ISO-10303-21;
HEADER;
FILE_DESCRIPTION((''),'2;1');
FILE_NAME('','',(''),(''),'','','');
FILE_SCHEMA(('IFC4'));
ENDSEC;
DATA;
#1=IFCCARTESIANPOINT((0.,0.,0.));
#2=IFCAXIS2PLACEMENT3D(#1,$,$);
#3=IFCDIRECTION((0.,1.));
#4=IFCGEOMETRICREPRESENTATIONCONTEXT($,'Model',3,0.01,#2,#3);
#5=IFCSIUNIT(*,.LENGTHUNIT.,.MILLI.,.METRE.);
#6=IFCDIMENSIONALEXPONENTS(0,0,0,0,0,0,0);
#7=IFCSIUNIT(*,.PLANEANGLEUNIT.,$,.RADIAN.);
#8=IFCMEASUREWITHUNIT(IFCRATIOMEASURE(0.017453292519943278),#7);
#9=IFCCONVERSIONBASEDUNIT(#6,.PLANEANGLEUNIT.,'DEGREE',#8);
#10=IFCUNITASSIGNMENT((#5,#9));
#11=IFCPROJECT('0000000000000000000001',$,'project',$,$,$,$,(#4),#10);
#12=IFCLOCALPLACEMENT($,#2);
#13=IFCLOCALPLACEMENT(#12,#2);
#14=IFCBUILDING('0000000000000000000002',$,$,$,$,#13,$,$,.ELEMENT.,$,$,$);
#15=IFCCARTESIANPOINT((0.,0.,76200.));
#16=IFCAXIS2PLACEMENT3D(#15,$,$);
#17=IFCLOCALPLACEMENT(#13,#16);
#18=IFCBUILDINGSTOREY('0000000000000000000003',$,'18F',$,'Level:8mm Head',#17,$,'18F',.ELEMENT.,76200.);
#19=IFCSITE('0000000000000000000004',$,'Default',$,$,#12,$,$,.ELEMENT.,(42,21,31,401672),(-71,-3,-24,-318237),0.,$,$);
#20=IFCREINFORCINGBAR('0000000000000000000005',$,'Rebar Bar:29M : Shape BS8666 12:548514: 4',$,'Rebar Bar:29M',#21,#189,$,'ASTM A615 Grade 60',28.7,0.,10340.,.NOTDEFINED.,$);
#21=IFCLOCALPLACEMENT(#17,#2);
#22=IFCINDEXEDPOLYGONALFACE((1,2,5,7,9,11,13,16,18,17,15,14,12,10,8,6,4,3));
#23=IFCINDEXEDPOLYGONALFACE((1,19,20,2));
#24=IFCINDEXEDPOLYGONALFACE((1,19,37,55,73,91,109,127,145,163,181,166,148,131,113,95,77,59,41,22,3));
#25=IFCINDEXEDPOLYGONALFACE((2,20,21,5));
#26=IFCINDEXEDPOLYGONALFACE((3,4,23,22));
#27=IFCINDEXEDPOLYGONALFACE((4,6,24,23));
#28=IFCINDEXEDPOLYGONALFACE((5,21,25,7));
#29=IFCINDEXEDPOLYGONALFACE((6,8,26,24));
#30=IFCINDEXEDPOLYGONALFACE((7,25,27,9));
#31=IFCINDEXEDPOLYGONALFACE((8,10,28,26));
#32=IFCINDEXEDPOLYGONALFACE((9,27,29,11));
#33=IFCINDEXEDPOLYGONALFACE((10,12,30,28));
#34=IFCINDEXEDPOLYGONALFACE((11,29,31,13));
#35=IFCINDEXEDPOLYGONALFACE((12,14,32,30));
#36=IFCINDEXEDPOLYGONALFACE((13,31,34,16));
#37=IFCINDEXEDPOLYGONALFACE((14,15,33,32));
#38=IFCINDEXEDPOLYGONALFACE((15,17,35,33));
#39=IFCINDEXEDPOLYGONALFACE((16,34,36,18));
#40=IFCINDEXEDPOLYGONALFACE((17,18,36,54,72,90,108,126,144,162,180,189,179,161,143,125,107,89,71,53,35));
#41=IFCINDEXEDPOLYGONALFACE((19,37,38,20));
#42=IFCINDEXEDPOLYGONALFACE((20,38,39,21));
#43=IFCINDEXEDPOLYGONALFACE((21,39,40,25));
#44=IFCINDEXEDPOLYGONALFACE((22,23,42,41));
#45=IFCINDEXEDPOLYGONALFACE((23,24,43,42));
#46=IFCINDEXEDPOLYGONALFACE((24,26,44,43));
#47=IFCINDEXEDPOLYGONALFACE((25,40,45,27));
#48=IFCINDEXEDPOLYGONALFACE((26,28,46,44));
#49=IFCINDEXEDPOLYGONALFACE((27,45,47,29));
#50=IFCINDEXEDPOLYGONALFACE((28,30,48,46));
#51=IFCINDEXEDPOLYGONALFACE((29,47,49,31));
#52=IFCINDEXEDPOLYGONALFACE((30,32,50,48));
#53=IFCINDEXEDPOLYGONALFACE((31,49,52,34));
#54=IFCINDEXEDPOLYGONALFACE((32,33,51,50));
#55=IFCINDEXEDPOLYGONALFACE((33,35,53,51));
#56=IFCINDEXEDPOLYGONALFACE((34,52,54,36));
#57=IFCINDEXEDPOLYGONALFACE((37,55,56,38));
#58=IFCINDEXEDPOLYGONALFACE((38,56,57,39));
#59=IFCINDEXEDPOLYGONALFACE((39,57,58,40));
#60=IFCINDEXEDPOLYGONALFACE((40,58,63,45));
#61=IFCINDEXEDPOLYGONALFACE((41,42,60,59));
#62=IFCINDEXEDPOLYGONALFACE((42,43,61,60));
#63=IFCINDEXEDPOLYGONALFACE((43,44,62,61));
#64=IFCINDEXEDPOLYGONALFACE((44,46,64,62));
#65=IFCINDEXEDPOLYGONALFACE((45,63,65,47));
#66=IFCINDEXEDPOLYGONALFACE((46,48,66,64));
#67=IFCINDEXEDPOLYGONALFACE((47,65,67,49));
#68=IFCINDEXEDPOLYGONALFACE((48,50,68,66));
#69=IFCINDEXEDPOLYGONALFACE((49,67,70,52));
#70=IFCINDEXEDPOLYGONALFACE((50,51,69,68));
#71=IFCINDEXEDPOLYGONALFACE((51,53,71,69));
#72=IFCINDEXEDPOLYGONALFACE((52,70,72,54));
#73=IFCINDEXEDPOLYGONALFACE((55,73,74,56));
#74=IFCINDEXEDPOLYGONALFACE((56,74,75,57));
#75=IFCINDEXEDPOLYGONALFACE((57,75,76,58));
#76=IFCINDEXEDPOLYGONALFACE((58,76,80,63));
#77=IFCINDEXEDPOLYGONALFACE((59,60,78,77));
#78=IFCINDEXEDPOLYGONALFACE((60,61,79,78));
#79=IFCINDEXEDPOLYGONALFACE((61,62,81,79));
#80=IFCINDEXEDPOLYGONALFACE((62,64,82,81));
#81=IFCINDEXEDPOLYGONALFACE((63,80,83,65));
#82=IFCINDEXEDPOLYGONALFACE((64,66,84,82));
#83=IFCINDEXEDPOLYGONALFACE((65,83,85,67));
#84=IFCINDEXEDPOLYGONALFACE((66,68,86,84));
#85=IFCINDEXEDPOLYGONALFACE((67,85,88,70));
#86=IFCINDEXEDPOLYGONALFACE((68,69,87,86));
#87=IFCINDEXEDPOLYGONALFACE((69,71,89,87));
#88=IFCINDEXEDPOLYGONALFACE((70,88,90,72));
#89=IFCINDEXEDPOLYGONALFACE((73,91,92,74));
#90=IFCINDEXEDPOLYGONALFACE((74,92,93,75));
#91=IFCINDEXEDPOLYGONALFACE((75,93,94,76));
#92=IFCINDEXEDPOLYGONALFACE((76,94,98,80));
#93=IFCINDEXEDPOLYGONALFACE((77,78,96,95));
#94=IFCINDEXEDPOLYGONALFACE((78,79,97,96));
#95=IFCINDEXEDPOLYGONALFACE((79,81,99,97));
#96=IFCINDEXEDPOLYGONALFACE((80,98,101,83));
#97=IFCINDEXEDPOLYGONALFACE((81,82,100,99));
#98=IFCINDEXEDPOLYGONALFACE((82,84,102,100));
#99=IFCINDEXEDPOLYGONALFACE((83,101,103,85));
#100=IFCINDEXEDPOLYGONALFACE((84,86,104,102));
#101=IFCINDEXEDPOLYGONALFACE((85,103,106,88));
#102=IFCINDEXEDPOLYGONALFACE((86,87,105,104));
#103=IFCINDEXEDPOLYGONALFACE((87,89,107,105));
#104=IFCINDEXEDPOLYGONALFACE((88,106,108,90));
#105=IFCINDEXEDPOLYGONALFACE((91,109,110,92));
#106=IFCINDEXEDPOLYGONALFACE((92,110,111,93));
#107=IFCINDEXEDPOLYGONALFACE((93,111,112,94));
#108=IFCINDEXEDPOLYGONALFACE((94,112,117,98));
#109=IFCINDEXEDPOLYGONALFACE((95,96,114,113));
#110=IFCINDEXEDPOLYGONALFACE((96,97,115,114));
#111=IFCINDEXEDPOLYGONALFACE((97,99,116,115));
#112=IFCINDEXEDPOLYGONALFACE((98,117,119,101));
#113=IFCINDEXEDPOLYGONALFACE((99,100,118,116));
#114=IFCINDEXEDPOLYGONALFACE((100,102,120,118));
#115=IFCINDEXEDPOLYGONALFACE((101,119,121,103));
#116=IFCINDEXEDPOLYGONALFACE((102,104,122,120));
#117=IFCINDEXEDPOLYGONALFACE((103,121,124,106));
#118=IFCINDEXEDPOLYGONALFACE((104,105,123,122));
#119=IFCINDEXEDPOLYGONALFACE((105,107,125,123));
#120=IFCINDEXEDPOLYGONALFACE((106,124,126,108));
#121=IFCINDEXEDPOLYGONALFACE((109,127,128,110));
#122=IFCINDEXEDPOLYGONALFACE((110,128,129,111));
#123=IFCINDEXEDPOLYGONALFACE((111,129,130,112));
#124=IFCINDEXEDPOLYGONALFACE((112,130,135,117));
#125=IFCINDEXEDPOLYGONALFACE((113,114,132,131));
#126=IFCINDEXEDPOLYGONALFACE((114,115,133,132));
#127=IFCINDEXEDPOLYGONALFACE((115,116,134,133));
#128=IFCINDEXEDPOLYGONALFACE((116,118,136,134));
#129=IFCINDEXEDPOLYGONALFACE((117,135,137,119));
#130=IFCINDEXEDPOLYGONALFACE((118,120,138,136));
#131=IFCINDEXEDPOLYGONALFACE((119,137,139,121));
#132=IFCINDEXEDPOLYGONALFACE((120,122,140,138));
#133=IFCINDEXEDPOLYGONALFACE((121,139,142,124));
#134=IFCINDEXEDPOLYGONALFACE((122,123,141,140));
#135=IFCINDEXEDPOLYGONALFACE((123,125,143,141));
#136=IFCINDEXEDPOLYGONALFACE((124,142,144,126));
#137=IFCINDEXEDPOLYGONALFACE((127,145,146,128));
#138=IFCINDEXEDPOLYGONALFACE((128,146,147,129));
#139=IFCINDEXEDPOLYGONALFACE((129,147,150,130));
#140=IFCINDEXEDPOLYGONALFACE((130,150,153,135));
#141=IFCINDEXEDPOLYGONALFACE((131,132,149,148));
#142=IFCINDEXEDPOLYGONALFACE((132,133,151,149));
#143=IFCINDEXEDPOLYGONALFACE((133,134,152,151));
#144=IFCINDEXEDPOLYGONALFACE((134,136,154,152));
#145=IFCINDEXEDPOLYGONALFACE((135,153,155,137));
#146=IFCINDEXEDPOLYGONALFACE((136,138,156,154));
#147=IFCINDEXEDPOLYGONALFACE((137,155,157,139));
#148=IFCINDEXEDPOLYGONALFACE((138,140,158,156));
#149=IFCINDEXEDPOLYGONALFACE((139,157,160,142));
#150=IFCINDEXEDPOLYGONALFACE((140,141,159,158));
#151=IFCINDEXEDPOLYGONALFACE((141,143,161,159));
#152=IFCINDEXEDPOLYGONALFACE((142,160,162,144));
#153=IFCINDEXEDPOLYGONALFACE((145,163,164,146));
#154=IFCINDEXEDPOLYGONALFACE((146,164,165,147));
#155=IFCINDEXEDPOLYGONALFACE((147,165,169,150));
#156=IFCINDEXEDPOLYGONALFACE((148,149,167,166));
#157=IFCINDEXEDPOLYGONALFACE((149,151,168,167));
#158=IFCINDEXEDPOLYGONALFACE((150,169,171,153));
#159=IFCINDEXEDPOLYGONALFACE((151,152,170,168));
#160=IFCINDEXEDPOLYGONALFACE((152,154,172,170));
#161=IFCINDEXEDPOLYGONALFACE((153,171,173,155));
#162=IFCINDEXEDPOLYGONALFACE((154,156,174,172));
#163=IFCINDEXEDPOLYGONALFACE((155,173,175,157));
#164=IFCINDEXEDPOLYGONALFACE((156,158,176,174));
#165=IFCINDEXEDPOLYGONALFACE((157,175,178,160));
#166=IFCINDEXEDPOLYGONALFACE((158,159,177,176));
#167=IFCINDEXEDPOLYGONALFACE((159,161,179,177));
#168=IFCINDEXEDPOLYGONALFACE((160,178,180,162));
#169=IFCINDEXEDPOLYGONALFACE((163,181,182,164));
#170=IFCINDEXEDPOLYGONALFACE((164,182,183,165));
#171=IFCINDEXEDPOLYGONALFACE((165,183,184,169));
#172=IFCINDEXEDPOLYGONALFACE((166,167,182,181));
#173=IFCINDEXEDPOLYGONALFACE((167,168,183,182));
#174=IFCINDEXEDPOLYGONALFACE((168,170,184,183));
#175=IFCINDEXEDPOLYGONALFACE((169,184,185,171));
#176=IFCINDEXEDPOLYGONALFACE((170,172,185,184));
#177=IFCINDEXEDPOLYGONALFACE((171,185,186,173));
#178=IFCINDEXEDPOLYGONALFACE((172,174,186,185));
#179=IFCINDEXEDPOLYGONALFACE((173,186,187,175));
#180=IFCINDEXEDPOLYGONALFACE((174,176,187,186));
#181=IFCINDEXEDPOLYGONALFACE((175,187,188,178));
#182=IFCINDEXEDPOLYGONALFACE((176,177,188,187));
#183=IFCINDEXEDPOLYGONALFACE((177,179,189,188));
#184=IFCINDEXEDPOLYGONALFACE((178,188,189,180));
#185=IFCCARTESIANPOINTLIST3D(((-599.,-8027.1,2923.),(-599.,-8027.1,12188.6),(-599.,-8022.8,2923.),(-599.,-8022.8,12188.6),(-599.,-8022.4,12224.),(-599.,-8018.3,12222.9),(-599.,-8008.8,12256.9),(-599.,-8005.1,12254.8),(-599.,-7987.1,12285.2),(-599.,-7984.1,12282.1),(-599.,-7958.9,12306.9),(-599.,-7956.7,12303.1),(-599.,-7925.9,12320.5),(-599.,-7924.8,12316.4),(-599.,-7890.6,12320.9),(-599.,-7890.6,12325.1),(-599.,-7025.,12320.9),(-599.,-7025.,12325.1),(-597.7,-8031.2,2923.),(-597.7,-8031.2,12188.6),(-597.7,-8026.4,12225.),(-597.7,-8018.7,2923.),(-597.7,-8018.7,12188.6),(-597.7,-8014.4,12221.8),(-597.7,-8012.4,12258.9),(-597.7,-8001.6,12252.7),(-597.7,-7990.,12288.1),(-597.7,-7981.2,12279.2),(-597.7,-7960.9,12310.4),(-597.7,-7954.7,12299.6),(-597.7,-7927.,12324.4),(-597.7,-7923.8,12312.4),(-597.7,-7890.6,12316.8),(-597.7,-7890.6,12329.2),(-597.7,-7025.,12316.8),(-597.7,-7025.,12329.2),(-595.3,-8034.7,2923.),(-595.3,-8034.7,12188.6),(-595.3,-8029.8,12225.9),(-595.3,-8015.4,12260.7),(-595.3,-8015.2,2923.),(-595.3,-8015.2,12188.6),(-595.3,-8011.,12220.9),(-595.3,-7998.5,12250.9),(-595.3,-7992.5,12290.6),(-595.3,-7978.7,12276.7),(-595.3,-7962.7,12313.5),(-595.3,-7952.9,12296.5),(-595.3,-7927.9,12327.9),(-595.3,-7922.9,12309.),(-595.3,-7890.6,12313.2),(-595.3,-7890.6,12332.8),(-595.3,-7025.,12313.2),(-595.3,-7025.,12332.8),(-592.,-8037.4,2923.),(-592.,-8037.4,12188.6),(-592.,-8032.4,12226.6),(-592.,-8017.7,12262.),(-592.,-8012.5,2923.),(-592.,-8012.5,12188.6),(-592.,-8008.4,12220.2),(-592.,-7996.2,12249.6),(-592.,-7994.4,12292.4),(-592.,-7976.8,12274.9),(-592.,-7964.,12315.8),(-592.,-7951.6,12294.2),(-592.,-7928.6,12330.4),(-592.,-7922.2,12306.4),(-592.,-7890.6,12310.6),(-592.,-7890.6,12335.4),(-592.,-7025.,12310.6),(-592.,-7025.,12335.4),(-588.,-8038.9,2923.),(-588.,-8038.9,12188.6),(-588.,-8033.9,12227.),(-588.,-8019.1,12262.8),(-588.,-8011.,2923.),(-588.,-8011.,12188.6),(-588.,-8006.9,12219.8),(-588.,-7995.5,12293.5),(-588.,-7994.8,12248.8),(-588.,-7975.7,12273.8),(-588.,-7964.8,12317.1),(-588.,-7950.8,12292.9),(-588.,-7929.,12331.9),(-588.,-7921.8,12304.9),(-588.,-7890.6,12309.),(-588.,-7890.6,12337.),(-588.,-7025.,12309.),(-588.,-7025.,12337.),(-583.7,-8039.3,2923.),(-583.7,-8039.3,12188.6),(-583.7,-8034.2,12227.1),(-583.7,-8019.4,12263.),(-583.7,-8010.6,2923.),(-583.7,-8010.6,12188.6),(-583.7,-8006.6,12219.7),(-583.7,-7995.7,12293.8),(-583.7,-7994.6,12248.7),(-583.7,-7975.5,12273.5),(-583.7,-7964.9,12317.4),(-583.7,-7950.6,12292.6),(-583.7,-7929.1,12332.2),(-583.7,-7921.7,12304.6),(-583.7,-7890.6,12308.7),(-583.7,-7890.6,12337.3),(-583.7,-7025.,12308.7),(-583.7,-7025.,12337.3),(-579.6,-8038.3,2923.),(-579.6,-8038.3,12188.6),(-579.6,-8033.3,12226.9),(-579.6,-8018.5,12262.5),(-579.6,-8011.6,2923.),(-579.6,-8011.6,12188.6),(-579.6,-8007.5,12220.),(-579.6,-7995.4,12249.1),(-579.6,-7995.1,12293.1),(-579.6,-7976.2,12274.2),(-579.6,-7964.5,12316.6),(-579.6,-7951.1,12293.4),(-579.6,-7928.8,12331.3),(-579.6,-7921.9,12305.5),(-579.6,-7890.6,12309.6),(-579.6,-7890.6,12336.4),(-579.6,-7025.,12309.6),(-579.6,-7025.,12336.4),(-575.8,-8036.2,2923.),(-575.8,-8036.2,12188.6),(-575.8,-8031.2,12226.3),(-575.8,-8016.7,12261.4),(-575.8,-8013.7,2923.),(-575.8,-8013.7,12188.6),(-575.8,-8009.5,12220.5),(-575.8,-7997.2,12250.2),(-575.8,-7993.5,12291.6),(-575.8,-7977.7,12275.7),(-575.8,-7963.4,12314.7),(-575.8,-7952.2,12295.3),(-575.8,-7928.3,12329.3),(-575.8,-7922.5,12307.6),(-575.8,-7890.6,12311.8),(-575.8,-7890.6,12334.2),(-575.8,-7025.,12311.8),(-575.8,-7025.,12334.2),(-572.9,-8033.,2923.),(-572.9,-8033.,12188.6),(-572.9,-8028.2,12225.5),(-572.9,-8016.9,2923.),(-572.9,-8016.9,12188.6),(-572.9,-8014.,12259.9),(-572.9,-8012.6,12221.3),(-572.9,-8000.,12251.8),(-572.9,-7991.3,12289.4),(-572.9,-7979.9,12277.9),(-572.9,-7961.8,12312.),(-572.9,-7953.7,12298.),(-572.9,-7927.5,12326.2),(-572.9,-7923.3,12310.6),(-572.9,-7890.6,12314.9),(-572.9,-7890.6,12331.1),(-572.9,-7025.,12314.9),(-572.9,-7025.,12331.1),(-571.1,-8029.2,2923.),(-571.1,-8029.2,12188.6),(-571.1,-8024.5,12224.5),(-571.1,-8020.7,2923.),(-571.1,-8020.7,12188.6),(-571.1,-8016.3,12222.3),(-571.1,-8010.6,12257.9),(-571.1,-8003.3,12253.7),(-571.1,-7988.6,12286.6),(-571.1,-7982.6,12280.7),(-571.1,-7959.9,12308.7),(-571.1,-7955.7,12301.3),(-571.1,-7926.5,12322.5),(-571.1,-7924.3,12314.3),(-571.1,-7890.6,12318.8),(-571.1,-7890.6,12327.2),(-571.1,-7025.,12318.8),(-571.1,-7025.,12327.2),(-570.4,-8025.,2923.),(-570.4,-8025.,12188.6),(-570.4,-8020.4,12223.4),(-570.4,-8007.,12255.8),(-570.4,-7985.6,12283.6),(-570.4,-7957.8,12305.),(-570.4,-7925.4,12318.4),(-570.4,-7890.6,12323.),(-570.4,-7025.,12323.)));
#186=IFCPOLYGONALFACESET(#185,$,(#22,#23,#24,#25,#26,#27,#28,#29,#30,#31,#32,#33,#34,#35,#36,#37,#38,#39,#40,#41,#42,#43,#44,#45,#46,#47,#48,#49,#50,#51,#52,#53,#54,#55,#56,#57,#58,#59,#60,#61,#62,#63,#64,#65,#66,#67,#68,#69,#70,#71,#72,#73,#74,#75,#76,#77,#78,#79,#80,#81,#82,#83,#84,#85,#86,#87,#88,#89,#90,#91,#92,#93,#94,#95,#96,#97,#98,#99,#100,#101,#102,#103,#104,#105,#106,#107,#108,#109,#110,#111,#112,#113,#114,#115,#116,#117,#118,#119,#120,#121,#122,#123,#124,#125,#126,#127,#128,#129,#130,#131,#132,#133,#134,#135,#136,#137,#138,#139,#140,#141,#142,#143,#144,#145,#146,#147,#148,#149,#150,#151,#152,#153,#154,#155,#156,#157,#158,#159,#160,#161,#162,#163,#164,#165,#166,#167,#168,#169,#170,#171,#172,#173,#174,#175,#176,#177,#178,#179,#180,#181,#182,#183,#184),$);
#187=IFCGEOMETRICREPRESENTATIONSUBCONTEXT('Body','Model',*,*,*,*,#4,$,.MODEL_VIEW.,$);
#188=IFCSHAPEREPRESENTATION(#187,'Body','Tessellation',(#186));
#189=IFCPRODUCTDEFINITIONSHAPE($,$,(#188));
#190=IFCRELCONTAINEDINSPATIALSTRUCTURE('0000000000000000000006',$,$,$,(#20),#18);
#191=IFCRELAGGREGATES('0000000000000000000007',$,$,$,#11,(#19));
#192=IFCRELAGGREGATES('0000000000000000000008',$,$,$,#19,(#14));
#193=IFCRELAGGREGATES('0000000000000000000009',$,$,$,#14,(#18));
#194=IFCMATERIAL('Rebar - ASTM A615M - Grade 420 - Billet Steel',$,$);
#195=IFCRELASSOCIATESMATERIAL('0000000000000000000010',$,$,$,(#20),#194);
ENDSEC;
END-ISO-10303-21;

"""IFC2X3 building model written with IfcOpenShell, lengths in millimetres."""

from ifc_helpers import new_model, entity, si_unit, converted_unit, direction, frame, origin, place, context, subcontext, project, spatial, material, element, save


model = new_model("IFC2X3")

# Units and contexts
model_context = context("Model", 3, precision=0.01, world=origin(), true_north=direction((0.0, 1.0)))
body_context = subcontext(model_context, "Body", "Model", "MODEL_VIEW")
ifc_project = project(units=[si_unit("LENGTHUNIT", "METRE", prefix="MILLI"), converted_unit("PLANEANGLEUNIT", "DEGREE", entity("IfcRatioMeasure", 0.017453292519943278), si_unit("PLANEANGLEUNIT", "RADIAN"), dimensions=[0, 0, 0, 0, 0, 0, 0])], contexts=[model_context])

# Site, building, storey
site_placement = place(None, origin())
site = spatial("IfcSite", under=ifc_project, at=site_placement, Name="Default", CompositionType="ELEMENT", RefLatitude=(42, 21, 31, 401672), RefLongitude=(-71, -3, -24, -318237), RefElevation=0.0)
building_placement = place(site_placement, origin())
building = spatial("IfcBuilding", under=site, at=building_placement, CompositionType="ELEMENT")
storey_placement = place(building_placement, frame((0.0, 0.0, 76200.0)))
storey = spatial("IfcBuildingStorey", under=building, at=storey_placement, Name="18F", ObjectType="Level:8mm Head", LongName="18F", CompositionType="ELEMENT", Elevation=76200.0)

# Reinforcing bar
ifc_material_1 = material(Name="Rebar - ASTM A615M - Grade 420 - Billet Steel")
reinforcing_bar_1_placement = place(storey_placement, origin())
element("IfcReinforcingBar", 1, at=reinforcing_bar_1_placement, inside=storey, material=ifc_material_1, Name="Rebar Bar:29M : Shape BS8666 12:548514: 4", SteelGrade="ASTM A615 Grade 60", ObjectType="Rebar Bar:29M", BarLength=10340.0, BarRole="NOTDEFINED", CrossSectionArea=0.0, NominalDiameter=28.7, context=body_context, shape_type="AdvancedSweptSolid", body=[
    entity("IfcSweptDiskSolid", entity("IfcCompositeCurve", [entity("IfcCompositeCurveSegment", "CONTINUOUS", True, entity("IfcPolyline", [entity("IfcCartesianPoint", [-584.8, -8025.0, 2923.0]), entity("IfcCartesianPoint", [-584.8, -8025.0, 12188.6])])), entity("IfcCompositeCurveSegment", "CONTINUOUS", True, entity("IfcTrimmedCurve", entity("IfcCircle", entity("IfcAxis2Placement3D", entity("IfcCartesianPoint", [-584.8, -7890.6, 12188.6]), entity("IfcDirection", [-1.0, 0.0, 0.0]), entity("IfcDirection", [0.0, 0.0, 1.0])), 134.3), [entity("IfcParameterValue", 270.0)], [entity("IfcParameterValue", 360.0)], True, "PARAMETER")), entity("IfcCompositeCurveSegment", "CONTINUOUS", True, entity("IfcPolyline", [entity("IfcCartesianPoint", [-584.8, -7890.6, 12323.0]), entity("IfcCartesianPoint", [-584.8, -7025.0, 12323.0])]))], False), 14.3, None, 0.0, 92.0),
])

save(model, "model.ifc")
